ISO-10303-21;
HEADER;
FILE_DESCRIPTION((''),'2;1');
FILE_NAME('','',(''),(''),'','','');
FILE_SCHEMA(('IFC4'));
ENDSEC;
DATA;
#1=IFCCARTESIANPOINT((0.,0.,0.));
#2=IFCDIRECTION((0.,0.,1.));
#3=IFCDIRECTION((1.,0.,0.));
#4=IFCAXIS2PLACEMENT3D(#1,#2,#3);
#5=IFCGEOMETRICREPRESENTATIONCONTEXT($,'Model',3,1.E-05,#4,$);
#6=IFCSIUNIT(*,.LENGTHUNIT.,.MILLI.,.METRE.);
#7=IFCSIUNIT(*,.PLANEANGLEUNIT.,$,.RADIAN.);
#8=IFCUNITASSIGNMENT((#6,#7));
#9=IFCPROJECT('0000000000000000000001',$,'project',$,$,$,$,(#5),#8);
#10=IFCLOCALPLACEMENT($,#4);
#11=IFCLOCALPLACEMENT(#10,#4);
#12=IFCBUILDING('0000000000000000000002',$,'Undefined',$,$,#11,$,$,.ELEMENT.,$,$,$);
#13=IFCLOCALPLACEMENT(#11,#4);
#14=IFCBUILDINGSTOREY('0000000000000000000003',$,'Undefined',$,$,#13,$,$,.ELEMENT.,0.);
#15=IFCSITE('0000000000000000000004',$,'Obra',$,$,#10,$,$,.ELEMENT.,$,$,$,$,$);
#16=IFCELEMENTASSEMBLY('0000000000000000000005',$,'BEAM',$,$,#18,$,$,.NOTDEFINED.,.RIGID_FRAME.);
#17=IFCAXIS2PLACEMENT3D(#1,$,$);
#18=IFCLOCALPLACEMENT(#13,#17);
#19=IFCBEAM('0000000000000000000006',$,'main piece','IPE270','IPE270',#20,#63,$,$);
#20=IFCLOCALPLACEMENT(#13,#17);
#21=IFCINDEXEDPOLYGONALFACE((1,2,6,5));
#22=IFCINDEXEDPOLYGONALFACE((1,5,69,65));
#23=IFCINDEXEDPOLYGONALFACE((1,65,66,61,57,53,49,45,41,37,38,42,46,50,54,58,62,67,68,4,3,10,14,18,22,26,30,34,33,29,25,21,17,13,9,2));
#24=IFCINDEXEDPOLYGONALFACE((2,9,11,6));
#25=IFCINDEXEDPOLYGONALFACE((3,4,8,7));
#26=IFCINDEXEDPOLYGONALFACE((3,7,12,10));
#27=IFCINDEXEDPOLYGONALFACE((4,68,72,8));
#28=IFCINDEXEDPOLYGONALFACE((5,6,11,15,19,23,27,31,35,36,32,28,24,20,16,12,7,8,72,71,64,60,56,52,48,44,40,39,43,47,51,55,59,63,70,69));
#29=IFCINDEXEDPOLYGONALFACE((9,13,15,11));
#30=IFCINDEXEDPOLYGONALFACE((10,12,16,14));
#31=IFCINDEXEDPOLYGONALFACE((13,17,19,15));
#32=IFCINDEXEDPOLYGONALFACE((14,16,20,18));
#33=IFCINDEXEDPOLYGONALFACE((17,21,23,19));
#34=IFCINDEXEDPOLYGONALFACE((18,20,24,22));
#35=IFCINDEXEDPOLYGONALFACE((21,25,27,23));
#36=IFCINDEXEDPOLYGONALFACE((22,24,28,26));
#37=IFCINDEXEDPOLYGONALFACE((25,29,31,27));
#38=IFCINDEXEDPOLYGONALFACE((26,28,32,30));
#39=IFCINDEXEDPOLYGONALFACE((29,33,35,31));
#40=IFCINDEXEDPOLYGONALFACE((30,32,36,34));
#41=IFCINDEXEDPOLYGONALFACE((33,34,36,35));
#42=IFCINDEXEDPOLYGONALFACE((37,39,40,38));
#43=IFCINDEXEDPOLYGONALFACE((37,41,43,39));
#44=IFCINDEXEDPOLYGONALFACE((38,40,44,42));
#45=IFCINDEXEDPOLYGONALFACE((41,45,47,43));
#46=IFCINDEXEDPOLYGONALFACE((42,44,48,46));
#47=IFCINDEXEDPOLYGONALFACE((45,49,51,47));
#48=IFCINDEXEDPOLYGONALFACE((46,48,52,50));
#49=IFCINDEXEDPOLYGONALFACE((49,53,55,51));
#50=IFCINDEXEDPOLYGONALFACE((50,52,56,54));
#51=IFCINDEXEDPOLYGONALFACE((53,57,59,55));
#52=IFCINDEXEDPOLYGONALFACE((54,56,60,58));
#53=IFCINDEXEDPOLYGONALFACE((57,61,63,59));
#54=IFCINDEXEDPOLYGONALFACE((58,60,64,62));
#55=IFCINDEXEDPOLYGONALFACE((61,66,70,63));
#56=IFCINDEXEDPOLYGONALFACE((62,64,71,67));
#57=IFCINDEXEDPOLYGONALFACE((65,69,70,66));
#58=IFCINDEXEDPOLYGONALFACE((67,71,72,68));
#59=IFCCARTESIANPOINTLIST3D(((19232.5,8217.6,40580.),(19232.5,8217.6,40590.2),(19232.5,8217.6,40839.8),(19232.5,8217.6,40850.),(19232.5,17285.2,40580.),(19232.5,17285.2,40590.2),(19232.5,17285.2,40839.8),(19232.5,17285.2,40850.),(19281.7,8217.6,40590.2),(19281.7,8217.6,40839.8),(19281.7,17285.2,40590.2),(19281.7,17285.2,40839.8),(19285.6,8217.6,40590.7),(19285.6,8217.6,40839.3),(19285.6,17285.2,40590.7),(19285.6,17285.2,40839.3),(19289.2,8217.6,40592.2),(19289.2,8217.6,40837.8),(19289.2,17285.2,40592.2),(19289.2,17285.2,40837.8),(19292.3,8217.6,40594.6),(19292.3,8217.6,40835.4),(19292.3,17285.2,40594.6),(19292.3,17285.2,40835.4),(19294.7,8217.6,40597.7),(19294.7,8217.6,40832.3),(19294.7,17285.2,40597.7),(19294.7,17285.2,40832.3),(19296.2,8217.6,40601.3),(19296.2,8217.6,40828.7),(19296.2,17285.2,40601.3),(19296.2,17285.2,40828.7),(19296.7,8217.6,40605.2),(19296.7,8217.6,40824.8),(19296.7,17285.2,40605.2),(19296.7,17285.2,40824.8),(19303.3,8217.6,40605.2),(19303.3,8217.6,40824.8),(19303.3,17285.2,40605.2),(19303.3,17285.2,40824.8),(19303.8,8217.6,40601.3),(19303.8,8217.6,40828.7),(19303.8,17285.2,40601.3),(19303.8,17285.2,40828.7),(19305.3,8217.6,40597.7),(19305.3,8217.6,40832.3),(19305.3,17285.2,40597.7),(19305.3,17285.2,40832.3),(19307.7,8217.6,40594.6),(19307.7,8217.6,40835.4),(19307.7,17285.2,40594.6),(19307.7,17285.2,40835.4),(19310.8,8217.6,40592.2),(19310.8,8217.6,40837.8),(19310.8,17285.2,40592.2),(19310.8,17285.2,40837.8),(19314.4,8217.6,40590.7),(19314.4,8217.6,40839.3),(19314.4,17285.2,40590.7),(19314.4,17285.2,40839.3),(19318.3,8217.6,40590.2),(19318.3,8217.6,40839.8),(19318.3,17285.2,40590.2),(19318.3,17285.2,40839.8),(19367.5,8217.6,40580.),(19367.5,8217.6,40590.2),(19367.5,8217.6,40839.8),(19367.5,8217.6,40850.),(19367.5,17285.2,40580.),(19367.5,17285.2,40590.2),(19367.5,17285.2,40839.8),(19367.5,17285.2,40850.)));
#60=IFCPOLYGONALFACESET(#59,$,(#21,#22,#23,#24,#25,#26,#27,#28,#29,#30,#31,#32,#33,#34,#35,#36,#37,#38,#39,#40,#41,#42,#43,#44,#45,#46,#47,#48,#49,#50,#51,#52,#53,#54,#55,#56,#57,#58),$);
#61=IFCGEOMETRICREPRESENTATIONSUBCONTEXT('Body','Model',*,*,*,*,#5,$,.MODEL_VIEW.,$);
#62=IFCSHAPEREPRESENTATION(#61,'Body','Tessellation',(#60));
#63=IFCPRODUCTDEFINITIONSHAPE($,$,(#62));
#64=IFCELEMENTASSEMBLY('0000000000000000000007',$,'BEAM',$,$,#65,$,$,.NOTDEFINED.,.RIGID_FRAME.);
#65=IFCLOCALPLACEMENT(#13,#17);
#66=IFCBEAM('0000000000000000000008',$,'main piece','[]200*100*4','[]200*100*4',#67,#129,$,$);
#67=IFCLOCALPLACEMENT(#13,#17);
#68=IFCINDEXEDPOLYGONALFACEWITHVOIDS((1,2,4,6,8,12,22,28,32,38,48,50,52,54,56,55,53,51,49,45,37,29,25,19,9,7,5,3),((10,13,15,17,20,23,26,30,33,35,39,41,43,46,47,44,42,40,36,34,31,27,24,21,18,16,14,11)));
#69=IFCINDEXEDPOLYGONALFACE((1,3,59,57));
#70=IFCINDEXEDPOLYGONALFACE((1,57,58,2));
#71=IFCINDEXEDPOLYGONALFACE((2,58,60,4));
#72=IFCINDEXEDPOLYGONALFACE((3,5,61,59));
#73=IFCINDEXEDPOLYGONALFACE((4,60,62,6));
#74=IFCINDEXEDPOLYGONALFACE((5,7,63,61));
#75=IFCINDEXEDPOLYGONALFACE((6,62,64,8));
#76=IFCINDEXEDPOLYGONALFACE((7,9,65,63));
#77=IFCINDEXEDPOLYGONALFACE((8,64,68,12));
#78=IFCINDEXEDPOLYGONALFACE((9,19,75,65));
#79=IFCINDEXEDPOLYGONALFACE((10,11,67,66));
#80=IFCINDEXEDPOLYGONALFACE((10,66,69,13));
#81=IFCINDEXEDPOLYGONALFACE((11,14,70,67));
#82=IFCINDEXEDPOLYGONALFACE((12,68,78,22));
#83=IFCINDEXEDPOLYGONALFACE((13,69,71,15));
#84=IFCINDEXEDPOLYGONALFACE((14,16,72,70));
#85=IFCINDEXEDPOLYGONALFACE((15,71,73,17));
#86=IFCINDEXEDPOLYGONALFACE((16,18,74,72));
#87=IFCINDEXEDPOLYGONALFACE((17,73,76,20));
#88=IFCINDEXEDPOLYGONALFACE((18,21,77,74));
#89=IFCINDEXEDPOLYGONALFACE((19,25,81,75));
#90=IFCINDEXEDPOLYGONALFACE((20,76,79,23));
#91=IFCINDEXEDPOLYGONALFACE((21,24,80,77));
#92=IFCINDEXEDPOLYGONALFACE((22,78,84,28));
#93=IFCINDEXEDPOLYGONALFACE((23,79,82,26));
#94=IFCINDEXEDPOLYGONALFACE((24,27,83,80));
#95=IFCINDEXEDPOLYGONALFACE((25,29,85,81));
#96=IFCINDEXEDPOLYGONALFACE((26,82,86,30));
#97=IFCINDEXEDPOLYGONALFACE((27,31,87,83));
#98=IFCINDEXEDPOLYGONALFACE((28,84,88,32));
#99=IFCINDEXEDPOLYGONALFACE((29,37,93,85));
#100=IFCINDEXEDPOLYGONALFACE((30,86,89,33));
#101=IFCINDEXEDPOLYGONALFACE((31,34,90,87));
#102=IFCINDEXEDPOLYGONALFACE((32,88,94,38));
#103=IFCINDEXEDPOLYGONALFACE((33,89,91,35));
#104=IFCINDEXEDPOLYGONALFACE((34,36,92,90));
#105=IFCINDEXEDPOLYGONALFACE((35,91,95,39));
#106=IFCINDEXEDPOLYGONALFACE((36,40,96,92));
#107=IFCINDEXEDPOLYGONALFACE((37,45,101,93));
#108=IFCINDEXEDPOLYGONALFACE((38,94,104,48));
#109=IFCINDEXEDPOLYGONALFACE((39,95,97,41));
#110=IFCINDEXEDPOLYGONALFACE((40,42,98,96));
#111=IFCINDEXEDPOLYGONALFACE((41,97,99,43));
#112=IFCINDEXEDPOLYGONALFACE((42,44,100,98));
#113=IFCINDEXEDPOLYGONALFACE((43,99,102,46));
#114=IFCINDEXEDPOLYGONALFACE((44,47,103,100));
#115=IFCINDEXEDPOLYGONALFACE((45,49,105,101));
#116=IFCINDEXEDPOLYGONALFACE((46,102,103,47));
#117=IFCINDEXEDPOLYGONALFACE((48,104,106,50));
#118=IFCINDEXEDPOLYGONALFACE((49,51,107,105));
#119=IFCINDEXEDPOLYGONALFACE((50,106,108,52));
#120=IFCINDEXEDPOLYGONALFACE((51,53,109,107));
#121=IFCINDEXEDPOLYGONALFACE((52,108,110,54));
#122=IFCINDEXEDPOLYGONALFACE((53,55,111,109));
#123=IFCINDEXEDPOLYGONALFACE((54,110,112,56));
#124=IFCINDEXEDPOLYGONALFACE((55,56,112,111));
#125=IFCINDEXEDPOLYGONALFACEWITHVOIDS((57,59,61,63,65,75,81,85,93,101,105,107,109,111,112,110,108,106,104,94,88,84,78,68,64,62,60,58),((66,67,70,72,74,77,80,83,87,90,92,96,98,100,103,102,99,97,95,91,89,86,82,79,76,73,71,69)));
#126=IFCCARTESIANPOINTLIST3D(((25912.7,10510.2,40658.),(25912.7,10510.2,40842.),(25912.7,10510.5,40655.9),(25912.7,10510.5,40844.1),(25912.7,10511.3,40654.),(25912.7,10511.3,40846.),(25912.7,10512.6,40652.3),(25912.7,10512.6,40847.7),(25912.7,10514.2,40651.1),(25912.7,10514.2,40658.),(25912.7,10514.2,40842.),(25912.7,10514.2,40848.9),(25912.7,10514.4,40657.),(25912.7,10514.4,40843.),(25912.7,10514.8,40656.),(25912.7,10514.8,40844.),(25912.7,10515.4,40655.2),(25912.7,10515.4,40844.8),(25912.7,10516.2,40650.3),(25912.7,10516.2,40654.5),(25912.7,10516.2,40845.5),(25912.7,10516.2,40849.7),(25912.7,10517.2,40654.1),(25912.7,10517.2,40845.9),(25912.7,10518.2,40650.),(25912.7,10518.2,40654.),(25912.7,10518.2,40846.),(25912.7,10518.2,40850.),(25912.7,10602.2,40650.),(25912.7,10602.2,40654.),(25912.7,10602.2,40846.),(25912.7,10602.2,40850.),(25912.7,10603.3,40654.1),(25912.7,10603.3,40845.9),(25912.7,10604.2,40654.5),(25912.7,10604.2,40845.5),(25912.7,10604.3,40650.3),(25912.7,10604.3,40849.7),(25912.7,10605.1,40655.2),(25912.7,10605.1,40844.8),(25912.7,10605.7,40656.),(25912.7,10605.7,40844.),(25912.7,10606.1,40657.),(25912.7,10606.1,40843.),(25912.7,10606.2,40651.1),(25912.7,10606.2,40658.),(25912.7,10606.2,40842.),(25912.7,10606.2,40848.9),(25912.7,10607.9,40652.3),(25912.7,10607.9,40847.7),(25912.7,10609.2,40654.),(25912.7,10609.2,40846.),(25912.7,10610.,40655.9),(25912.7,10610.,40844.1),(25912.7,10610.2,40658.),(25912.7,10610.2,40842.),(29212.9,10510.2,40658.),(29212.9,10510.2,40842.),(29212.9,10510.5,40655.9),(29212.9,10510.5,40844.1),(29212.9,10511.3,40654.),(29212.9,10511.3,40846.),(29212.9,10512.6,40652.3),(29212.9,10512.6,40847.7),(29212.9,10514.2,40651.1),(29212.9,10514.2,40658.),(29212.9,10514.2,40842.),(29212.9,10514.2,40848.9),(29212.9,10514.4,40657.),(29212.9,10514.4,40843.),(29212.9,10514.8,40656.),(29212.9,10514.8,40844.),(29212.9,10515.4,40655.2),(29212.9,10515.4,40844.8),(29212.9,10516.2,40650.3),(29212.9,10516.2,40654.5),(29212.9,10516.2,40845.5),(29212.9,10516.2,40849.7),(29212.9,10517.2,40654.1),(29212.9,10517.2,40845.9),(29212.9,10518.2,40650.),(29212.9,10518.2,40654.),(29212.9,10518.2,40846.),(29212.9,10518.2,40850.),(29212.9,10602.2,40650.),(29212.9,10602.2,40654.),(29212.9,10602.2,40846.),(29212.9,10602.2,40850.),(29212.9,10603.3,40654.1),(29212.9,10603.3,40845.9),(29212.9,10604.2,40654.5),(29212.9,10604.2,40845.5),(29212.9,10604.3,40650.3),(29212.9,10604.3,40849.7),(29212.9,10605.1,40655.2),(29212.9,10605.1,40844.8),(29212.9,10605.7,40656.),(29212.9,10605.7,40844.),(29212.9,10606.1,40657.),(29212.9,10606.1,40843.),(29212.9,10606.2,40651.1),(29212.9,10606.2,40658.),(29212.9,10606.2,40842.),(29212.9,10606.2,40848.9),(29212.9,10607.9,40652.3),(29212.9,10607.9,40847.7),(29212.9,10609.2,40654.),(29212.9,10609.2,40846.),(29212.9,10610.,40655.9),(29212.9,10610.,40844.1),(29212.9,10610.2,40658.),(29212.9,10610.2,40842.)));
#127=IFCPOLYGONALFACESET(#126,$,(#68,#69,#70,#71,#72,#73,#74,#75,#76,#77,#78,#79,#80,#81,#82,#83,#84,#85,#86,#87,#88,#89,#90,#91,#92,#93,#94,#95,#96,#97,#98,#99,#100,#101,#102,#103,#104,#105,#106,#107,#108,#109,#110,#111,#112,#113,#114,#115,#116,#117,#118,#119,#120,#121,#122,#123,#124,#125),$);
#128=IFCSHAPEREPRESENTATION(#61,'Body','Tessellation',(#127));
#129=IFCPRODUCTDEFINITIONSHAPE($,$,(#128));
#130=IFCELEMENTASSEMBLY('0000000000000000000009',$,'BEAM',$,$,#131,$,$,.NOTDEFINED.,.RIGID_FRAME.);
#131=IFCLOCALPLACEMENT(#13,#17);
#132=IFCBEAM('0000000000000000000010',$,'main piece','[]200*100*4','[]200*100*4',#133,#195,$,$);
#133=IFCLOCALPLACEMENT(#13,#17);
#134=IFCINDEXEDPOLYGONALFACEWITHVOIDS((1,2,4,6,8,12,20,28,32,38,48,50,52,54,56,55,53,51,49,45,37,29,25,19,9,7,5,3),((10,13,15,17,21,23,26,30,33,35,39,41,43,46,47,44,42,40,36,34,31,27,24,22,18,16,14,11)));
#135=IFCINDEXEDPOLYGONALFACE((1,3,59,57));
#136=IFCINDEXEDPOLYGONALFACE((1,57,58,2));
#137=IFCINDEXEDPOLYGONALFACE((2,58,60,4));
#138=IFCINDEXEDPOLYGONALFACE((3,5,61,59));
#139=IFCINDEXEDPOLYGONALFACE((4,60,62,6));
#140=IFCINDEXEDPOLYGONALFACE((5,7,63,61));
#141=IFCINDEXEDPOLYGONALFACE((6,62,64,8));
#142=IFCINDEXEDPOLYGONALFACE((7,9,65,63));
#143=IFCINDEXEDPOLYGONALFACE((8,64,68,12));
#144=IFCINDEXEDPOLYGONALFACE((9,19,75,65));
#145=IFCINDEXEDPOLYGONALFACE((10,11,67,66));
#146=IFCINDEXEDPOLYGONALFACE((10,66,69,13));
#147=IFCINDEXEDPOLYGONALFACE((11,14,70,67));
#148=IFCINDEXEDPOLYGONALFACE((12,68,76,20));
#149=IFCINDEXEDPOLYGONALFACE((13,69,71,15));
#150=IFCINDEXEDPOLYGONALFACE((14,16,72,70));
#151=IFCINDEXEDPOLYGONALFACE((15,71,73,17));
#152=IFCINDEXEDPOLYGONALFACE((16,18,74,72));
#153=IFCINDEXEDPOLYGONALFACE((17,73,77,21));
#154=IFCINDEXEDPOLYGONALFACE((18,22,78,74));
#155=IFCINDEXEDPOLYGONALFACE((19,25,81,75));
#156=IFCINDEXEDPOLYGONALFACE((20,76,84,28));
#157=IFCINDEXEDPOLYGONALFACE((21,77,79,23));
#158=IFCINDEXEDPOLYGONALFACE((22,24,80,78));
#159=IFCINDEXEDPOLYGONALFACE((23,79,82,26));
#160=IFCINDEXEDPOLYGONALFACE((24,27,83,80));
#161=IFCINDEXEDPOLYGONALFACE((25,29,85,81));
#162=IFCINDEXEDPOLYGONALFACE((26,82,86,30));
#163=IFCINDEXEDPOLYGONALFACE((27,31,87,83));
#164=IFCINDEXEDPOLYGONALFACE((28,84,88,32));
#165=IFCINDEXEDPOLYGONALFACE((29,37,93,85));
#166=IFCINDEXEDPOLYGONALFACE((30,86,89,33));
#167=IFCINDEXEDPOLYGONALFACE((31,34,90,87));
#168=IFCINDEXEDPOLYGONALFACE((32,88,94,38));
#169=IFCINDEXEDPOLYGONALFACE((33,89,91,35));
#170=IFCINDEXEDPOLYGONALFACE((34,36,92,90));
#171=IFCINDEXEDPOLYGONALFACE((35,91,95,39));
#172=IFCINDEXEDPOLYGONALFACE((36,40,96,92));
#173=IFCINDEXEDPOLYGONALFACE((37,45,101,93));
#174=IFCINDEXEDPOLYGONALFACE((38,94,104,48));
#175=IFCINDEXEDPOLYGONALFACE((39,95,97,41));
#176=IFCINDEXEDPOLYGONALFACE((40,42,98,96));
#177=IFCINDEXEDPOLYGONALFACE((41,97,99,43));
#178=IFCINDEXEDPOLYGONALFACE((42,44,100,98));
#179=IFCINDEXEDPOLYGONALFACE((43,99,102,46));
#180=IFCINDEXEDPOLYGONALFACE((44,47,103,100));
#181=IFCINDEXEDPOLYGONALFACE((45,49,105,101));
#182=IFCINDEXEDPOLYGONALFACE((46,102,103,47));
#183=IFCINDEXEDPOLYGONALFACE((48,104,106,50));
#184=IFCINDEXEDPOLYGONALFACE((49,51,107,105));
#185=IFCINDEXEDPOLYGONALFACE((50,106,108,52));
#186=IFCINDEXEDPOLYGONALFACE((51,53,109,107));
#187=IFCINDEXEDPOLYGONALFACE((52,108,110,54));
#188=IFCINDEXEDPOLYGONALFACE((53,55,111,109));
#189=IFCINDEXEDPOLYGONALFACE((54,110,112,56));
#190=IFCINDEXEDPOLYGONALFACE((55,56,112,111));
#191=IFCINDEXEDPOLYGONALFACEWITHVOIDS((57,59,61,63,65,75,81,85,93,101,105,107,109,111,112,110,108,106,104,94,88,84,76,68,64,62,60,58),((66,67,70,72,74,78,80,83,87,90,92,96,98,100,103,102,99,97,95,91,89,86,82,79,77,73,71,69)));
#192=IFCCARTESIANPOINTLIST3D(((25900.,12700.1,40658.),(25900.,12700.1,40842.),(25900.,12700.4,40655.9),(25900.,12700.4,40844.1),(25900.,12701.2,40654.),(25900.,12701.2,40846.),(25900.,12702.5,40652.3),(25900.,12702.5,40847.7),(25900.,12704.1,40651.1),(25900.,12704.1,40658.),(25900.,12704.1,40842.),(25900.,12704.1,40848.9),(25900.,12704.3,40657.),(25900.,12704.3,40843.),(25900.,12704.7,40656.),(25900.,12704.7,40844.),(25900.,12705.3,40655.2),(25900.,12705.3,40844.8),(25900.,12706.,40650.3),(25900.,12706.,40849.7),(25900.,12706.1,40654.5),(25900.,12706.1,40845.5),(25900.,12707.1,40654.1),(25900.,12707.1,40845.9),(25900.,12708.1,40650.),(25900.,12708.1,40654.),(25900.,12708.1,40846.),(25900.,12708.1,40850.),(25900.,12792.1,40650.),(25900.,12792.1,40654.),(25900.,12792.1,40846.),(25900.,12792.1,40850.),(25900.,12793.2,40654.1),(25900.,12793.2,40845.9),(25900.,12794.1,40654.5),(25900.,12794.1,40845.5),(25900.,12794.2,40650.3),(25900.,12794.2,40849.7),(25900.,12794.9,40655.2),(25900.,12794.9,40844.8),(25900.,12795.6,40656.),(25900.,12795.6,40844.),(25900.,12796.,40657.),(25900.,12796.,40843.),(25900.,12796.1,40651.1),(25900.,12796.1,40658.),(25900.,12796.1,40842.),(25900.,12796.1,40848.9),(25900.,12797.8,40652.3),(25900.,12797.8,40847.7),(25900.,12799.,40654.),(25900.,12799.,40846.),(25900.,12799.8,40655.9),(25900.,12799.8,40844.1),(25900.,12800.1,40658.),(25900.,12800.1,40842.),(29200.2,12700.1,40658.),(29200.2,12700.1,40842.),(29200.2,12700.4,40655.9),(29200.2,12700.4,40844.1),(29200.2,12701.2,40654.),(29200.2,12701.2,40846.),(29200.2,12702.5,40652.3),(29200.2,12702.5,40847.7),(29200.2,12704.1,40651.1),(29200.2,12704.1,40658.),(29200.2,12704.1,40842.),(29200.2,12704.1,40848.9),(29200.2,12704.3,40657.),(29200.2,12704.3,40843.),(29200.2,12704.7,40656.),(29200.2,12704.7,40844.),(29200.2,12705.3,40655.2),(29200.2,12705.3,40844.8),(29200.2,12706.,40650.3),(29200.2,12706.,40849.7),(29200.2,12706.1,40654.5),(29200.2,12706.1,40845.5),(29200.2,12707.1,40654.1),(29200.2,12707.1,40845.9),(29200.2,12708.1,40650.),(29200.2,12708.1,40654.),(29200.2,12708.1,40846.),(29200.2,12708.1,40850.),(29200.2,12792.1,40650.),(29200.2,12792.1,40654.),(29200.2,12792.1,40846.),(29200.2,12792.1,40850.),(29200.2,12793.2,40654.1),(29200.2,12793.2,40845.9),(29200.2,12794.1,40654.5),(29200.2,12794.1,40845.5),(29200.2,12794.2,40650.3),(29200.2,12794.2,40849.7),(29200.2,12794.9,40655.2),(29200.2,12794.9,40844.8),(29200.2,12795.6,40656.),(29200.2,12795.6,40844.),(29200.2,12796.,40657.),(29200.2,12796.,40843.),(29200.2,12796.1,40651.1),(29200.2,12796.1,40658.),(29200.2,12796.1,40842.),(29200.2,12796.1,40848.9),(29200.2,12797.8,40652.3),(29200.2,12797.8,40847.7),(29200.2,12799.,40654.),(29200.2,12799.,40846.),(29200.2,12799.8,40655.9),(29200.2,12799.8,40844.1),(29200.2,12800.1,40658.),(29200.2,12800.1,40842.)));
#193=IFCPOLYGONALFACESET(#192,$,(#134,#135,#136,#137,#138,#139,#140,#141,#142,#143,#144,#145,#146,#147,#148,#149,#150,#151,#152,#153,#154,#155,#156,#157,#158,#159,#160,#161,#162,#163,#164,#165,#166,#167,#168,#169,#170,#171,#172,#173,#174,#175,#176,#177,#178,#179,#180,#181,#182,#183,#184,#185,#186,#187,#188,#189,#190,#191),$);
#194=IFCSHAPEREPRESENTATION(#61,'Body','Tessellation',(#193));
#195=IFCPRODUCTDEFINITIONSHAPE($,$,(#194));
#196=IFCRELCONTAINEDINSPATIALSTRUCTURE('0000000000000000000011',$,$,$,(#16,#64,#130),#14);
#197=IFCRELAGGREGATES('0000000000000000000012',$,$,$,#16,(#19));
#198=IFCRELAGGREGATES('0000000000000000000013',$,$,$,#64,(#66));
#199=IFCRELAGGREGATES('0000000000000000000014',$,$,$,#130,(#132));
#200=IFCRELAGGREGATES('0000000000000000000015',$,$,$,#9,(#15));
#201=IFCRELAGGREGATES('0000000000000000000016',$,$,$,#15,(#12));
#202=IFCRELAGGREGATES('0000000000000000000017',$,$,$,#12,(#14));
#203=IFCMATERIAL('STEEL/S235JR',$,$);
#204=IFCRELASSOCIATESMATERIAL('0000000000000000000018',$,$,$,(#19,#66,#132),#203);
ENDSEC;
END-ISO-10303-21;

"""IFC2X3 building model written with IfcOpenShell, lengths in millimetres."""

from ifc_helpers import new_model, si_unit, frame, origin_with_axes, origin_2d_with_axis, place, context, subcontext, project, spatial, hollow_rectangle, i_section, extrude, material, element, aggregate, save


model = new_model("IFC2X3")

# Units and contexts
model_context = context("Model", 3, precision=1e-05, world=origin_with_axes())
body_context = subcontext(model_context, "Body", "Model", "MODEL_VIEW")
ifc_project = project(units=[si_unit("LENGTHUNIT", "METRE", prefix="MILLI"), si_unit("PLANEANGLEUNIT", "RADIAN")], contexts=[model_context])

# Site, building, storey
site_placement = place(None, origin_with_axes())
site = spatial("IfcSite", under=ifc_project, at=site_placement, Name="Obra", CompositionType="ELEMENT")
building_placement = place(site_placement, origin_with_axes())
building = spatial("IfcBuilding", under=site, at=building_placement, Name="Undefined", CompositionType="ELEMENT")
storey_placement = place(building_placement, origin_with_axes())
storey = spatial("IfcBuildingStorey", under=building, at=storey_placement, Name="Undefined", CompositionType="ELEMENT", Elevation=0.0)

# Element assemblies, beams
ifc_material_1 = material(Name="STEEL/S235JR")
assembly_1_placement = place(storey_placement, origin_with_axes())
assembly_1 = element("IfcElementAssembly", 1, at=assembly_1_placement, inside=storey, Name="BEAM", AssemblyPlace="NOTDEFINED", PredefinedType="RIGID_FRAME")
beam_1_placement = place(assembly_1_placement, frame((19300.0, 8217.6, 40715.0), z_axis=(0.0, 0.0, 1.0), x_axis=(0.0, 1.0, 0.0)))
beam_1 = element("IfcBeam", 2, at=beam_1_placement, material=ifc_material_1, Name="main piece", Description="IPE270", ObjectType="IPE270", context=body_context, shape_type="SweptSolid", body=[
    extrude(i_section(OverallWidth=135.0, OverallDepth=270.0, WebThickness=6.6, FlangeThickness=10.2, FilletRadius=15.0, at=origin_2d_with_axis()), frame((9067.6, 0.0, 0.0), z_axis=(-1.0, 0.0, 0.0), x_axis=(0.0, -1.0, 0.0)), (0.0, 0.0, 1.0), 9067.6),
])
aggregate(assembly_1, [beam_1])
assembly_2_placement = place(storey_placement, origin_with_axes())
assembly_2 = element("IfcElementAssembly", 3, at=assembly_2_placement, inside=storey, Name="BEAM", AssemblyPlace="NOTDEFINED", PredefinedType="RIGID_FRAME")
beam_2_placement = place(assembly_2_placement, frame((25912.7, 10560.2, 40750.0), z_axis=(0.0, 0.0, 1.0), x_axis=(1.0, 0.0, 0.0)))
beam_2 = element("IfcBeam", 4, at=beam_2_placement, material=ifc_material_1, Name="main piece", Description="[]200*100*4", ObjectType="[]200*100*4", context=body_context, shape_type="SweptSolid", body=[
    extrude(hollow_rectangle(XDim=100.0, YDim=200.0, WallThickness=4.0, InnerFilletRadius=4.0, OuterFilletRadius=8.0, at=origin_2d_with_axis()), frame((3300.2, 0.0, 0.0), z_axis=(-1.0, 0.0, 0.0), x_axis=(0.0, -1.0, 0.0)), (0.0, 0.0, 1.0), 3300.2),
])
aggregate(assembly_2, [beam_2])
assembly_3_placement = place(storey_placement, origin_with_axes())
assembly_3 = element("IfcElementAssembly", 5, at=assembly_3_placement, inside=storey, Name="BEAM", AssemblyPlace="NOTDEFINED", PredefinedType="RIGID_FRAME")
beam_3_placement = place(assembly_3_placement, frame((25900.0, 12750.1, 40750.0), z_axis=(0.0, 0.0, 1.0), x_axis=(1.0, 0.0, 0.0)))
beam_3 = element("IfcBeam", 6, at=beam_3_placement, material=ifc_material_1, Name="main piece", Description="[]200*100*4", ObjectType="[]200*100*4", context=body_context, shape_type="SweptSolid", body=[
    extrude(hollow_rectangle(XDim=100.0, YDim=200.0, WallThickness=4.0, InnerFilletRadius=4.0, OuterFilletRadius=8.0, at=origin_2d_with_axis()), frame((3300.2, 0.0, 0.0), z_axis=(-1.0, 0.0, 0.0), x_axis=(0.0, -1.0, 0.0)), (0.0, 0.0, 1.0), 3300.2),
])
aggregate(assembly_3, [beam_3])

save(model, "model.ifc")
